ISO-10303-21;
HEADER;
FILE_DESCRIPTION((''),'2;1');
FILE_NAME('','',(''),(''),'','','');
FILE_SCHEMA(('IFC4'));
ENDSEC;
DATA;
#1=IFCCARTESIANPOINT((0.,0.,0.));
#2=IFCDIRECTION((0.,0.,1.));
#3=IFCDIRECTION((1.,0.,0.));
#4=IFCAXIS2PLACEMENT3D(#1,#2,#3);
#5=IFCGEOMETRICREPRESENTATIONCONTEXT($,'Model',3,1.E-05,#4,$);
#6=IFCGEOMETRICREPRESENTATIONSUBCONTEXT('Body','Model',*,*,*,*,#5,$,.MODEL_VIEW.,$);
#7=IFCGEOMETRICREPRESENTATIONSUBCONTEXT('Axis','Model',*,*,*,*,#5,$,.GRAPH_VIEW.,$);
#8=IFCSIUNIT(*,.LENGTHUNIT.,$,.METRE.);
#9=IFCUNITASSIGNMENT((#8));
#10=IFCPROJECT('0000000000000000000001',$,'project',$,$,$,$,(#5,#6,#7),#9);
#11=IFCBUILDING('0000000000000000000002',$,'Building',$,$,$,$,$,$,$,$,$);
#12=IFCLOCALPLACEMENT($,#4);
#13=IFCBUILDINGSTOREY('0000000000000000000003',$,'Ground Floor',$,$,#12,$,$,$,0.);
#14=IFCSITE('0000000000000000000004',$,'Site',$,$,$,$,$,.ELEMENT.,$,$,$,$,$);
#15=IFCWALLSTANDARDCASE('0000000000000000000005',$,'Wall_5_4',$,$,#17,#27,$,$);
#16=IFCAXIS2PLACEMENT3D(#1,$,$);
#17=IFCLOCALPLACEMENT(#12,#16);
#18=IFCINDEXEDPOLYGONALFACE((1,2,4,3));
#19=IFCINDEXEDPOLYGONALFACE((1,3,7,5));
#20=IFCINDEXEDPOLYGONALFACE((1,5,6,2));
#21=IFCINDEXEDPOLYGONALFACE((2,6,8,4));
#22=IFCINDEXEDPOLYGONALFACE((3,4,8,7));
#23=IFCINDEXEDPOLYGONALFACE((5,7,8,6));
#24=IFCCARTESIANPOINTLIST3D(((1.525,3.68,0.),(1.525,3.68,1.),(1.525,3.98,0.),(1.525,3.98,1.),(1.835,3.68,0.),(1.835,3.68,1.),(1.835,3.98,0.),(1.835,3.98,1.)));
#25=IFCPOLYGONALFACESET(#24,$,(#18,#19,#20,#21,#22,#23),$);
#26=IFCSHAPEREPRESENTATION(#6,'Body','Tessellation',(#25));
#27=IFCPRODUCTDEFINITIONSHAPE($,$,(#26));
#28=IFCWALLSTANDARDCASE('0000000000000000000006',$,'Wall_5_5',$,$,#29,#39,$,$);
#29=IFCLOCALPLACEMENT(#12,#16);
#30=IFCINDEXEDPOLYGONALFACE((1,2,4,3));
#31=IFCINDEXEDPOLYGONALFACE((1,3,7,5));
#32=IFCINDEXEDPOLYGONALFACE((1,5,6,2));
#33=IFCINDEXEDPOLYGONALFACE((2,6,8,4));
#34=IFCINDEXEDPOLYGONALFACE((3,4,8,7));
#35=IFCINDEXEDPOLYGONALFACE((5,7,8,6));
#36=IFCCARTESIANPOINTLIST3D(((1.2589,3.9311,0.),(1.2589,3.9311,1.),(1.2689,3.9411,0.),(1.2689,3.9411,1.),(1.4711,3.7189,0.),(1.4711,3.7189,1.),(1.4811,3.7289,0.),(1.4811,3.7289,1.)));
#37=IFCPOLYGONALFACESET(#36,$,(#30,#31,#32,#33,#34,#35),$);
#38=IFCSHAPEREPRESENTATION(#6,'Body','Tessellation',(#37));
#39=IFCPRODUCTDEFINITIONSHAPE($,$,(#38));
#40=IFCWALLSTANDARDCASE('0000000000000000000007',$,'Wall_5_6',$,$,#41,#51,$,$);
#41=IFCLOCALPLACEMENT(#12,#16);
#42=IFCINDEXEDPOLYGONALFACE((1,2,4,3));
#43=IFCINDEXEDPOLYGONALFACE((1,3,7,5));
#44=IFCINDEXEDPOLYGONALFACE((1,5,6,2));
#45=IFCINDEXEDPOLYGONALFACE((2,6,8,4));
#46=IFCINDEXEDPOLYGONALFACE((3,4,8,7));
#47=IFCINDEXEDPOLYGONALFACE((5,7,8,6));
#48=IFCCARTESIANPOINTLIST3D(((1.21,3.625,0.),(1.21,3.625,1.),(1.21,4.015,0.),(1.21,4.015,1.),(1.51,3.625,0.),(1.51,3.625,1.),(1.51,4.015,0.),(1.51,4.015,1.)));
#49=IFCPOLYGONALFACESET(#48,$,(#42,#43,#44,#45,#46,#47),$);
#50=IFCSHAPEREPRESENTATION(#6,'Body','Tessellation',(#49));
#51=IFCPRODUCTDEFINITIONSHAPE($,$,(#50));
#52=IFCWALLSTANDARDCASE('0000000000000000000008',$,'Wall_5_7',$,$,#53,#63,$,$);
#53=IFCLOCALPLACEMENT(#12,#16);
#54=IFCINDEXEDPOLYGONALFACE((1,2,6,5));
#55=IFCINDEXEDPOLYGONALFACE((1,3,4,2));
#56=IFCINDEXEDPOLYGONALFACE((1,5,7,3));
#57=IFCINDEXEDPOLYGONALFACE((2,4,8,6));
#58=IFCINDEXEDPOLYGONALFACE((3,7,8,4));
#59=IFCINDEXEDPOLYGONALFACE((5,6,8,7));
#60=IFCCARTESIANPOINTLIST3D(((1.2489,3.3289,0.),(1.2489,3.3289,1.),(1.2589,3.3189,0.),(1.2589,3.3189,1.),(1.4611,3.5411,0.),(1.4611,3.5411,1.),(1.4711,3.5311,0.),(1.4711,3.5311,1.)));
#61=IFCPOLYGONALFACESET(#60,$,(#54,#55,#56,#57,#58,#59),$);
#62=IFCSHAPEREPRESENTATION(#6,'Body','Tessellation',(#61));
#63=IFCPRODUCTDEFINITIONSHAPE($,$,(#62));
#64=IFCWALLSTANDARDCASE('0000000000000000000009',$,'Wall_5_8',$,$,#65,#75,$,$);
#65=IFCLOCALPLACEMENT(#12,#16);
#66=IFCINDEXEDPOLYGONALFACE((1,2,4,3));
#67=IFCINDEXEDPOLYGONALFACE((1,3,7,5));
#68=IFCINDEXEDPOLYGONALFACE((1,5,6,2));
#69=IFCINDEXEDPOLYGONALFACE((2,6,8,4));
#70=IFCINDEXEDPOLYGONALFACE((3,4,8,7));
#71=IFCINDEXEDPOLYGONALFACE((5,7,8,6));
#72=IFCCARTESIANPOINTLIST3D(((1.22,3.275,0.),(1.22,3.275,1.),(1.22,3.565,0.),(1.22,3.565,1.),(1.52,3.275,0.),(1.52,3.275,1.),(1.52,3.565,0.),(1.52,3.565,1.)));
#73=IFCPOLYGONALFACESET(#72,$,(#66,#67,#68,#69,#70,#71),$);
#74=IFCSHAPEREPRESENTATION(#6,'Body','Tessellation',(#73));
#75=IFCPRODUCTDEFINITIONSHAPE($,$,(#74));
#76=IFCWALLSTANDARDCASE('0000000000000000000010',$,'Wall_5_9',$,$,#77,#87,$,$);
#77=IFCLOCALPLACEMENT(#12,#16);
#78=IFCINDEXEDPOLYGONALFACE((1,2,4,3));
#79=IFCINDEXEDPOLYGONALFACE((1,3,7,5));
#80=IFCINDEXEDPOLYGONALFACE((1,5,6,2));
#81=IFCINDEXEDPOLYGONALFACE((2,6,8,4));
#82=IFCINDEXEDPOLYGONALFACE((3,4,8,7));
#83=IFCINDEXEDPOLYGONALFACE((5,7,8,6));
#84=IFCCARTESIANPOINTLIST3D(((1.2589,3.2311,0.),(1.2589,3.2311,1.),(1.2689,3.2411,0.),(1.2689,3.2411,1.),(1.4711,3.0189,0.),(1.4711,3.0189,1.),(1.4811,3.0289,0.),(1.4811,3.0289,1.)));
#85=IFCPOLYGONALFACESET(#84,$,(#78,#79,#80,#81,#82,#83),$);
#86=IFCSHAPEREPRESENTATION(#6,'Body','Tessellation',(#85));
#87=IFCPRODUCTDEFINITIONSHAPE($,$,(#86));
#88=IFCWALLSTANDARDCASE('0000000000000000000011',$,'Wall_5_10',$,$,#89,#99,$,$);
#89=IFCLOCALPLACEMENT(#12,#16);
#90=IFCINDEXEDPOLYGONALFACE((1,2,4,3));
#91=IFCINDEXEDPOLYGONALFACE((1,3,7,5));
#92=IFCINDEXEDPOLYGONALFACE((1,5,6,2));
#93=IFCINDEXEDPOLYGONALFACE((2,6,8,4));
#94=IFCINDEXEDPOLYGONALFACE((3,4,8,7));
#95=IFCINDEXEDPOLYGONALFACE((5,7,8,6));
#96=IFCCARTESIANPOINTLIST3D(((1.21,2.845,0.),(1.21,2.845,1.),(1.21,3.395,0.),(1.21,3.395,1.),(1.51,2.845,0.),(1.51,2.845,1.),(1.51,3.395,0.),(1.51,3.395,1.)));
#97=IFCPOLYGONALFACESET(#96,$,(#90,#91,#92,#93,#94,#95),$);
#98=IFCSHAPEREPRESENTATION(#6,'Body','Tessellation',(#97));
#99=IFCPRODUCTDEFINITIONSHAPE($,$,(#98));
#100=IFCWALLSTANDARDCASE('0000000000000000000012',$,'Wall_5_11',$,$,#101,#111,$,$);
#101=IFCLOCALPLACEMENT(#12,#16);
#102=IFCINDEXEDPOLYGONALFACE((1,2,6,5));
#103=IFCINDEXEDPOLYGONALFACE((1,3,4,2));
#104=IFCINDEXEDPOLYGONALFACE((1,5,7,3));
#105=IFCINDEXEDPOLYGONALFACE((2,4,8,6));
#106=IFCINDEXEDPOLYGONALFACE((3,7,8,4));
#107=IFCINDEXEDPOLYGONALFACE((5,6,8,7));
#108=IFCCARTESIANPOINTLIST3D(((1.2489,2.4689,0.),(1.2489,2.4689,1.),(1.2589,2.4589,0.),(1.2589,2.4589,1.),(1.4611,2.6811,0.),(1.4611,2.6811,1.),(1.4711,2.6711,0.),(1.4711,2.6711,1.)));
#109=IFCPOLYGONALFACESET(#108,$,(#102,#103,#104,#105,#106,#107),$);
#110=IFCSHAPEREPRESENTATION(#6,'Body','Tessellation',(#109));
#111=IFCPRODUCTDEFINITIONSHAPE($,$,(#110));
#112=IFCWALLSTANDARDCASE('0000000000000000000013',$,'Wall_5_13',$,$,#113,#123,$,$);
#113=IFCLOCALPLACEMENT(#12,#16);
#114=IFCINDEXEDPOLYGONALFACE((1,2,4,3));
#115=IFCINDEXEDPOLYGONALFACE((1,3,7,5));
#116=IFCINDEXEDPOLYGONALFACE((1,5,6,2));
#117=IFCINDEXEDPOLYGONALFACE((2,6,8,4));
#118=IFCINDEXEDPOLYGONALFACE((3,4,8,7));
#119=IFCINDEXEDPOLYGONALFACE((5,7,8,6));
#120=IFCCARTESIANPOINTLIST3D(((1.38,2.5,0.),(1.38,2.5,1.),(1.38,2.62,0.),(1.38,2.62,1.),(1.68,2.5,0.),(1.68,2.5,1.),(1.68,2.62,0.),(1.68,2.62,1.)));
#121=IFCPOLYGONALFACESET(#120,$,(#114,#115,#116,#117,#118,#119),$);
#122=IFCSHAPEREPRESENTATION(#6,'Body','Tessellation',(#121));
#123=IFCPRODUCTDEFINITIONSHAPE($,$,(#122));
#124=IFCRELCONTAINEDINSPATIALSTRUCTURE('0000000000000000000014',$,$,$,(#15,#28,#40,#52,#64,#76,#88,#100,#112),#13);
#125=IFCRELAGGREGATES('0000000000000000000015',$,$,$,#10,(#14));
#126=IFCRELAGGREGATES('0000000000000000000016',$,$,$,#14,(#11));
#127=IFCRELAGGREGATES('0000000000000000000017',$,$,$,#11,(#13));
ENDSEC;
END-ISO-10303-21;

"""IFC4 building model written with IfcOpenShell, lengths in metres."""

from ifc_helpers import new_model, si_unit, frame, origin_with_axes, origin_2d, place, context, subcontext, project, spatial, rectangle, extrude, element, save


model = new_model("IFC4")

# Units and contexts
model_context = context("Model", 3, precision=1e-05, world=origin_with_axes())
body_context = subcontext(model_context, "Body", "Model", "MODEL_VIEW")
axis_context = subcontext(model_context, "Axis", "Model", "GRAPH_VIEW")
ifc_project = project(units=[si_unit("LENGTHUNIT", "METRE")], contexts=[model_context, body_context, axis_context])

# Site, building, storey
site = spatial("IfcSite", under=ifc_project, Name="Site", CompositionType="ELEMENT")
building = spatial("IfcBuilding", under=site, Name="Building")
storey_placement = place(None, origin_with_axes())
storey = spatial("IfcBuildingStorey", under=building, at=storey_placement, Name="Ground Floor", Elevation=0.0)

# Walls
wall_1_placement = place(storey_placement, frame((1.68, 3.83, 0.0), z_axis=(0.0, 0.0, 1.0), x_axis=(-1.0, 0.0, 0.0)))
element("IfcWallStandardCase", 1, at=wall_1_placement, inside=storey, Name="Wall_5_4", context=body_context, shape_type="SweptSolid", body=[
    extrude(rectangle(XDim=0.31, YDim=0.3, at=origin_2d()), origin_with_axes(), (0.0, 0.0, 1.0), 1.0),
])
wall_2_placement = place(storey_placement, frame((1.37, 3.83, 0.0), z_axis=(0.0, 0.0, 1.0), x_axis=(-0.707107, -0.707107, 0.0)))
element("IfcWallStandardCase", 2, at=wall_2_placement, inside=storey, Name="Wall_5_5", context=body_context, shape_type="SweptSolid", body=[
    extrude(rectangle(XDim=0.0141, YDim=0.3, at=origin_2d()), origin_with_axes(), (0.0, 0.0, 1.0), 1.0),
])
wall_3_placement = place(storey_placement, frame((1.36, 3.82, 0.0), z_axis=(0.0, 0.0, 1.0), x_axis=(0.0, -1.0, 0.0)))
element("IfcWallStandardCase", 3, at=wall_3_placement, inside=storey, Name="Wall_5_6", context=body_context, shape_type="SweptSolid", body=[
    extrude(rectangle(XDim=0.39, YDim=0.3, at=origin_2d()), origin_with_axes(), (0.0, 0.0, 1.0), 1.0),
])
wall_4_placement = place(storey_placement, frame((1.36, 3.43, 0.0), z_axis=(0.0, 0.0, 1.0), x_axis=(0.707107, -0.707107, 0.0)))
element("IfcWallStandardCase", 4, at=wall_4_placement, inside=storey, Name="Wall_5_7", context=body_context, shape_type="SweptSolid", body=[
    extrude(rectangle(XDim=0.0141, YDim=0.3, at=origin_2d()), origin_with_axes(), (0.0, 0.0, 1.0), 1.0),
])
wall_5_placement = place(storey_placement, frame((1.37, 3.42, 0.0), z_axis=(0.0, 0.0, 1.0), x_axis=(0.0, -1.0, 0.0)))
element("IfcWallStandardCase", 5, at=wall_5_placement, inside=storey, Name="Wall_5_8", context=body_context, shape_type="SweptSolid", body=[
    extrude(rectangle(XDim=0.29, YDim=0.3, at=origin_2d()), origin_with_axes(), (0.0, 0.0, 1.0), 1.0),
])
wall_6_placement = place(storey_placement, frame((1.37, 3.13, 0.0), z_axis=(0.0, 0.0, 1.0), x_axis=(-0.707107, -0.707107, 0.0)))
element("IfcWallStandardCase", 6, at=wall_6_placement, inside=storey, Name="Wall_5_9", context=body_context, shape_type="SweptSolid", body=[
    extrude(rectangle(XDim=0.0141, YDim=0.3, at=origin_2d()), origin_with_axes(), (0.0, 0.0, 1.0), 1.0),
])
wall_7_placement = place(storey_placement, frame((1.36, 3.12, 0.0), z_axis=(0.0, 0.0, 1.0), x_axis=(0.0, -1.0, 0.0)))
element("IfcWallStandardCase", 7, at=wall_7_placement, inside=storey, Name="Wall_5_10", context=body_context, shape_type="SweptSolid", body=[
    extrude(rectangle(XDim=0.55, YDim=0.3, at=origin_2d()), origin_with_axes(), (0.0, 0.0, 1.0), 1.0),
])
wall_8_placement = place(storey_placement, frame((1.36, 2.57, 0.0), z_axis=(0.0, 0.0, 1.0), x_axis=(0.707107, -0.707107, 0.0)))
element("IfcWallStandardCase", 8, at=wall_8_placement, inside=storey, Name="Wall_5_11", context=body_context, shape_type="SweptSolid", body=[
    extrude(rectangle(XDim=0.0141, YDim=0.3, at=origin_2d()), origin_with_axes(), (0.0, 0.0, 1.0), 1.0),
])
wall_9_placement = place(storey_placement, frame((1.53, 2.56, 0.0), z_axis=(0.0, 0.0, 1.0), x_axis=(0.0, -1.0, 0.0)))
element("IfcWallStandardCase", 9, at=wall_9_placement, inside=storey, Name="Wall_5_13", context=body_context, shape_type="SweptSolid", body=[
    extrude(rectangle(XDim=0.12, YDim=0.3, at=origin_2d()), origin_with_axes(), (0.0, 0.0, 1.0), 1.0),
])

save(model, "model.ifc")
